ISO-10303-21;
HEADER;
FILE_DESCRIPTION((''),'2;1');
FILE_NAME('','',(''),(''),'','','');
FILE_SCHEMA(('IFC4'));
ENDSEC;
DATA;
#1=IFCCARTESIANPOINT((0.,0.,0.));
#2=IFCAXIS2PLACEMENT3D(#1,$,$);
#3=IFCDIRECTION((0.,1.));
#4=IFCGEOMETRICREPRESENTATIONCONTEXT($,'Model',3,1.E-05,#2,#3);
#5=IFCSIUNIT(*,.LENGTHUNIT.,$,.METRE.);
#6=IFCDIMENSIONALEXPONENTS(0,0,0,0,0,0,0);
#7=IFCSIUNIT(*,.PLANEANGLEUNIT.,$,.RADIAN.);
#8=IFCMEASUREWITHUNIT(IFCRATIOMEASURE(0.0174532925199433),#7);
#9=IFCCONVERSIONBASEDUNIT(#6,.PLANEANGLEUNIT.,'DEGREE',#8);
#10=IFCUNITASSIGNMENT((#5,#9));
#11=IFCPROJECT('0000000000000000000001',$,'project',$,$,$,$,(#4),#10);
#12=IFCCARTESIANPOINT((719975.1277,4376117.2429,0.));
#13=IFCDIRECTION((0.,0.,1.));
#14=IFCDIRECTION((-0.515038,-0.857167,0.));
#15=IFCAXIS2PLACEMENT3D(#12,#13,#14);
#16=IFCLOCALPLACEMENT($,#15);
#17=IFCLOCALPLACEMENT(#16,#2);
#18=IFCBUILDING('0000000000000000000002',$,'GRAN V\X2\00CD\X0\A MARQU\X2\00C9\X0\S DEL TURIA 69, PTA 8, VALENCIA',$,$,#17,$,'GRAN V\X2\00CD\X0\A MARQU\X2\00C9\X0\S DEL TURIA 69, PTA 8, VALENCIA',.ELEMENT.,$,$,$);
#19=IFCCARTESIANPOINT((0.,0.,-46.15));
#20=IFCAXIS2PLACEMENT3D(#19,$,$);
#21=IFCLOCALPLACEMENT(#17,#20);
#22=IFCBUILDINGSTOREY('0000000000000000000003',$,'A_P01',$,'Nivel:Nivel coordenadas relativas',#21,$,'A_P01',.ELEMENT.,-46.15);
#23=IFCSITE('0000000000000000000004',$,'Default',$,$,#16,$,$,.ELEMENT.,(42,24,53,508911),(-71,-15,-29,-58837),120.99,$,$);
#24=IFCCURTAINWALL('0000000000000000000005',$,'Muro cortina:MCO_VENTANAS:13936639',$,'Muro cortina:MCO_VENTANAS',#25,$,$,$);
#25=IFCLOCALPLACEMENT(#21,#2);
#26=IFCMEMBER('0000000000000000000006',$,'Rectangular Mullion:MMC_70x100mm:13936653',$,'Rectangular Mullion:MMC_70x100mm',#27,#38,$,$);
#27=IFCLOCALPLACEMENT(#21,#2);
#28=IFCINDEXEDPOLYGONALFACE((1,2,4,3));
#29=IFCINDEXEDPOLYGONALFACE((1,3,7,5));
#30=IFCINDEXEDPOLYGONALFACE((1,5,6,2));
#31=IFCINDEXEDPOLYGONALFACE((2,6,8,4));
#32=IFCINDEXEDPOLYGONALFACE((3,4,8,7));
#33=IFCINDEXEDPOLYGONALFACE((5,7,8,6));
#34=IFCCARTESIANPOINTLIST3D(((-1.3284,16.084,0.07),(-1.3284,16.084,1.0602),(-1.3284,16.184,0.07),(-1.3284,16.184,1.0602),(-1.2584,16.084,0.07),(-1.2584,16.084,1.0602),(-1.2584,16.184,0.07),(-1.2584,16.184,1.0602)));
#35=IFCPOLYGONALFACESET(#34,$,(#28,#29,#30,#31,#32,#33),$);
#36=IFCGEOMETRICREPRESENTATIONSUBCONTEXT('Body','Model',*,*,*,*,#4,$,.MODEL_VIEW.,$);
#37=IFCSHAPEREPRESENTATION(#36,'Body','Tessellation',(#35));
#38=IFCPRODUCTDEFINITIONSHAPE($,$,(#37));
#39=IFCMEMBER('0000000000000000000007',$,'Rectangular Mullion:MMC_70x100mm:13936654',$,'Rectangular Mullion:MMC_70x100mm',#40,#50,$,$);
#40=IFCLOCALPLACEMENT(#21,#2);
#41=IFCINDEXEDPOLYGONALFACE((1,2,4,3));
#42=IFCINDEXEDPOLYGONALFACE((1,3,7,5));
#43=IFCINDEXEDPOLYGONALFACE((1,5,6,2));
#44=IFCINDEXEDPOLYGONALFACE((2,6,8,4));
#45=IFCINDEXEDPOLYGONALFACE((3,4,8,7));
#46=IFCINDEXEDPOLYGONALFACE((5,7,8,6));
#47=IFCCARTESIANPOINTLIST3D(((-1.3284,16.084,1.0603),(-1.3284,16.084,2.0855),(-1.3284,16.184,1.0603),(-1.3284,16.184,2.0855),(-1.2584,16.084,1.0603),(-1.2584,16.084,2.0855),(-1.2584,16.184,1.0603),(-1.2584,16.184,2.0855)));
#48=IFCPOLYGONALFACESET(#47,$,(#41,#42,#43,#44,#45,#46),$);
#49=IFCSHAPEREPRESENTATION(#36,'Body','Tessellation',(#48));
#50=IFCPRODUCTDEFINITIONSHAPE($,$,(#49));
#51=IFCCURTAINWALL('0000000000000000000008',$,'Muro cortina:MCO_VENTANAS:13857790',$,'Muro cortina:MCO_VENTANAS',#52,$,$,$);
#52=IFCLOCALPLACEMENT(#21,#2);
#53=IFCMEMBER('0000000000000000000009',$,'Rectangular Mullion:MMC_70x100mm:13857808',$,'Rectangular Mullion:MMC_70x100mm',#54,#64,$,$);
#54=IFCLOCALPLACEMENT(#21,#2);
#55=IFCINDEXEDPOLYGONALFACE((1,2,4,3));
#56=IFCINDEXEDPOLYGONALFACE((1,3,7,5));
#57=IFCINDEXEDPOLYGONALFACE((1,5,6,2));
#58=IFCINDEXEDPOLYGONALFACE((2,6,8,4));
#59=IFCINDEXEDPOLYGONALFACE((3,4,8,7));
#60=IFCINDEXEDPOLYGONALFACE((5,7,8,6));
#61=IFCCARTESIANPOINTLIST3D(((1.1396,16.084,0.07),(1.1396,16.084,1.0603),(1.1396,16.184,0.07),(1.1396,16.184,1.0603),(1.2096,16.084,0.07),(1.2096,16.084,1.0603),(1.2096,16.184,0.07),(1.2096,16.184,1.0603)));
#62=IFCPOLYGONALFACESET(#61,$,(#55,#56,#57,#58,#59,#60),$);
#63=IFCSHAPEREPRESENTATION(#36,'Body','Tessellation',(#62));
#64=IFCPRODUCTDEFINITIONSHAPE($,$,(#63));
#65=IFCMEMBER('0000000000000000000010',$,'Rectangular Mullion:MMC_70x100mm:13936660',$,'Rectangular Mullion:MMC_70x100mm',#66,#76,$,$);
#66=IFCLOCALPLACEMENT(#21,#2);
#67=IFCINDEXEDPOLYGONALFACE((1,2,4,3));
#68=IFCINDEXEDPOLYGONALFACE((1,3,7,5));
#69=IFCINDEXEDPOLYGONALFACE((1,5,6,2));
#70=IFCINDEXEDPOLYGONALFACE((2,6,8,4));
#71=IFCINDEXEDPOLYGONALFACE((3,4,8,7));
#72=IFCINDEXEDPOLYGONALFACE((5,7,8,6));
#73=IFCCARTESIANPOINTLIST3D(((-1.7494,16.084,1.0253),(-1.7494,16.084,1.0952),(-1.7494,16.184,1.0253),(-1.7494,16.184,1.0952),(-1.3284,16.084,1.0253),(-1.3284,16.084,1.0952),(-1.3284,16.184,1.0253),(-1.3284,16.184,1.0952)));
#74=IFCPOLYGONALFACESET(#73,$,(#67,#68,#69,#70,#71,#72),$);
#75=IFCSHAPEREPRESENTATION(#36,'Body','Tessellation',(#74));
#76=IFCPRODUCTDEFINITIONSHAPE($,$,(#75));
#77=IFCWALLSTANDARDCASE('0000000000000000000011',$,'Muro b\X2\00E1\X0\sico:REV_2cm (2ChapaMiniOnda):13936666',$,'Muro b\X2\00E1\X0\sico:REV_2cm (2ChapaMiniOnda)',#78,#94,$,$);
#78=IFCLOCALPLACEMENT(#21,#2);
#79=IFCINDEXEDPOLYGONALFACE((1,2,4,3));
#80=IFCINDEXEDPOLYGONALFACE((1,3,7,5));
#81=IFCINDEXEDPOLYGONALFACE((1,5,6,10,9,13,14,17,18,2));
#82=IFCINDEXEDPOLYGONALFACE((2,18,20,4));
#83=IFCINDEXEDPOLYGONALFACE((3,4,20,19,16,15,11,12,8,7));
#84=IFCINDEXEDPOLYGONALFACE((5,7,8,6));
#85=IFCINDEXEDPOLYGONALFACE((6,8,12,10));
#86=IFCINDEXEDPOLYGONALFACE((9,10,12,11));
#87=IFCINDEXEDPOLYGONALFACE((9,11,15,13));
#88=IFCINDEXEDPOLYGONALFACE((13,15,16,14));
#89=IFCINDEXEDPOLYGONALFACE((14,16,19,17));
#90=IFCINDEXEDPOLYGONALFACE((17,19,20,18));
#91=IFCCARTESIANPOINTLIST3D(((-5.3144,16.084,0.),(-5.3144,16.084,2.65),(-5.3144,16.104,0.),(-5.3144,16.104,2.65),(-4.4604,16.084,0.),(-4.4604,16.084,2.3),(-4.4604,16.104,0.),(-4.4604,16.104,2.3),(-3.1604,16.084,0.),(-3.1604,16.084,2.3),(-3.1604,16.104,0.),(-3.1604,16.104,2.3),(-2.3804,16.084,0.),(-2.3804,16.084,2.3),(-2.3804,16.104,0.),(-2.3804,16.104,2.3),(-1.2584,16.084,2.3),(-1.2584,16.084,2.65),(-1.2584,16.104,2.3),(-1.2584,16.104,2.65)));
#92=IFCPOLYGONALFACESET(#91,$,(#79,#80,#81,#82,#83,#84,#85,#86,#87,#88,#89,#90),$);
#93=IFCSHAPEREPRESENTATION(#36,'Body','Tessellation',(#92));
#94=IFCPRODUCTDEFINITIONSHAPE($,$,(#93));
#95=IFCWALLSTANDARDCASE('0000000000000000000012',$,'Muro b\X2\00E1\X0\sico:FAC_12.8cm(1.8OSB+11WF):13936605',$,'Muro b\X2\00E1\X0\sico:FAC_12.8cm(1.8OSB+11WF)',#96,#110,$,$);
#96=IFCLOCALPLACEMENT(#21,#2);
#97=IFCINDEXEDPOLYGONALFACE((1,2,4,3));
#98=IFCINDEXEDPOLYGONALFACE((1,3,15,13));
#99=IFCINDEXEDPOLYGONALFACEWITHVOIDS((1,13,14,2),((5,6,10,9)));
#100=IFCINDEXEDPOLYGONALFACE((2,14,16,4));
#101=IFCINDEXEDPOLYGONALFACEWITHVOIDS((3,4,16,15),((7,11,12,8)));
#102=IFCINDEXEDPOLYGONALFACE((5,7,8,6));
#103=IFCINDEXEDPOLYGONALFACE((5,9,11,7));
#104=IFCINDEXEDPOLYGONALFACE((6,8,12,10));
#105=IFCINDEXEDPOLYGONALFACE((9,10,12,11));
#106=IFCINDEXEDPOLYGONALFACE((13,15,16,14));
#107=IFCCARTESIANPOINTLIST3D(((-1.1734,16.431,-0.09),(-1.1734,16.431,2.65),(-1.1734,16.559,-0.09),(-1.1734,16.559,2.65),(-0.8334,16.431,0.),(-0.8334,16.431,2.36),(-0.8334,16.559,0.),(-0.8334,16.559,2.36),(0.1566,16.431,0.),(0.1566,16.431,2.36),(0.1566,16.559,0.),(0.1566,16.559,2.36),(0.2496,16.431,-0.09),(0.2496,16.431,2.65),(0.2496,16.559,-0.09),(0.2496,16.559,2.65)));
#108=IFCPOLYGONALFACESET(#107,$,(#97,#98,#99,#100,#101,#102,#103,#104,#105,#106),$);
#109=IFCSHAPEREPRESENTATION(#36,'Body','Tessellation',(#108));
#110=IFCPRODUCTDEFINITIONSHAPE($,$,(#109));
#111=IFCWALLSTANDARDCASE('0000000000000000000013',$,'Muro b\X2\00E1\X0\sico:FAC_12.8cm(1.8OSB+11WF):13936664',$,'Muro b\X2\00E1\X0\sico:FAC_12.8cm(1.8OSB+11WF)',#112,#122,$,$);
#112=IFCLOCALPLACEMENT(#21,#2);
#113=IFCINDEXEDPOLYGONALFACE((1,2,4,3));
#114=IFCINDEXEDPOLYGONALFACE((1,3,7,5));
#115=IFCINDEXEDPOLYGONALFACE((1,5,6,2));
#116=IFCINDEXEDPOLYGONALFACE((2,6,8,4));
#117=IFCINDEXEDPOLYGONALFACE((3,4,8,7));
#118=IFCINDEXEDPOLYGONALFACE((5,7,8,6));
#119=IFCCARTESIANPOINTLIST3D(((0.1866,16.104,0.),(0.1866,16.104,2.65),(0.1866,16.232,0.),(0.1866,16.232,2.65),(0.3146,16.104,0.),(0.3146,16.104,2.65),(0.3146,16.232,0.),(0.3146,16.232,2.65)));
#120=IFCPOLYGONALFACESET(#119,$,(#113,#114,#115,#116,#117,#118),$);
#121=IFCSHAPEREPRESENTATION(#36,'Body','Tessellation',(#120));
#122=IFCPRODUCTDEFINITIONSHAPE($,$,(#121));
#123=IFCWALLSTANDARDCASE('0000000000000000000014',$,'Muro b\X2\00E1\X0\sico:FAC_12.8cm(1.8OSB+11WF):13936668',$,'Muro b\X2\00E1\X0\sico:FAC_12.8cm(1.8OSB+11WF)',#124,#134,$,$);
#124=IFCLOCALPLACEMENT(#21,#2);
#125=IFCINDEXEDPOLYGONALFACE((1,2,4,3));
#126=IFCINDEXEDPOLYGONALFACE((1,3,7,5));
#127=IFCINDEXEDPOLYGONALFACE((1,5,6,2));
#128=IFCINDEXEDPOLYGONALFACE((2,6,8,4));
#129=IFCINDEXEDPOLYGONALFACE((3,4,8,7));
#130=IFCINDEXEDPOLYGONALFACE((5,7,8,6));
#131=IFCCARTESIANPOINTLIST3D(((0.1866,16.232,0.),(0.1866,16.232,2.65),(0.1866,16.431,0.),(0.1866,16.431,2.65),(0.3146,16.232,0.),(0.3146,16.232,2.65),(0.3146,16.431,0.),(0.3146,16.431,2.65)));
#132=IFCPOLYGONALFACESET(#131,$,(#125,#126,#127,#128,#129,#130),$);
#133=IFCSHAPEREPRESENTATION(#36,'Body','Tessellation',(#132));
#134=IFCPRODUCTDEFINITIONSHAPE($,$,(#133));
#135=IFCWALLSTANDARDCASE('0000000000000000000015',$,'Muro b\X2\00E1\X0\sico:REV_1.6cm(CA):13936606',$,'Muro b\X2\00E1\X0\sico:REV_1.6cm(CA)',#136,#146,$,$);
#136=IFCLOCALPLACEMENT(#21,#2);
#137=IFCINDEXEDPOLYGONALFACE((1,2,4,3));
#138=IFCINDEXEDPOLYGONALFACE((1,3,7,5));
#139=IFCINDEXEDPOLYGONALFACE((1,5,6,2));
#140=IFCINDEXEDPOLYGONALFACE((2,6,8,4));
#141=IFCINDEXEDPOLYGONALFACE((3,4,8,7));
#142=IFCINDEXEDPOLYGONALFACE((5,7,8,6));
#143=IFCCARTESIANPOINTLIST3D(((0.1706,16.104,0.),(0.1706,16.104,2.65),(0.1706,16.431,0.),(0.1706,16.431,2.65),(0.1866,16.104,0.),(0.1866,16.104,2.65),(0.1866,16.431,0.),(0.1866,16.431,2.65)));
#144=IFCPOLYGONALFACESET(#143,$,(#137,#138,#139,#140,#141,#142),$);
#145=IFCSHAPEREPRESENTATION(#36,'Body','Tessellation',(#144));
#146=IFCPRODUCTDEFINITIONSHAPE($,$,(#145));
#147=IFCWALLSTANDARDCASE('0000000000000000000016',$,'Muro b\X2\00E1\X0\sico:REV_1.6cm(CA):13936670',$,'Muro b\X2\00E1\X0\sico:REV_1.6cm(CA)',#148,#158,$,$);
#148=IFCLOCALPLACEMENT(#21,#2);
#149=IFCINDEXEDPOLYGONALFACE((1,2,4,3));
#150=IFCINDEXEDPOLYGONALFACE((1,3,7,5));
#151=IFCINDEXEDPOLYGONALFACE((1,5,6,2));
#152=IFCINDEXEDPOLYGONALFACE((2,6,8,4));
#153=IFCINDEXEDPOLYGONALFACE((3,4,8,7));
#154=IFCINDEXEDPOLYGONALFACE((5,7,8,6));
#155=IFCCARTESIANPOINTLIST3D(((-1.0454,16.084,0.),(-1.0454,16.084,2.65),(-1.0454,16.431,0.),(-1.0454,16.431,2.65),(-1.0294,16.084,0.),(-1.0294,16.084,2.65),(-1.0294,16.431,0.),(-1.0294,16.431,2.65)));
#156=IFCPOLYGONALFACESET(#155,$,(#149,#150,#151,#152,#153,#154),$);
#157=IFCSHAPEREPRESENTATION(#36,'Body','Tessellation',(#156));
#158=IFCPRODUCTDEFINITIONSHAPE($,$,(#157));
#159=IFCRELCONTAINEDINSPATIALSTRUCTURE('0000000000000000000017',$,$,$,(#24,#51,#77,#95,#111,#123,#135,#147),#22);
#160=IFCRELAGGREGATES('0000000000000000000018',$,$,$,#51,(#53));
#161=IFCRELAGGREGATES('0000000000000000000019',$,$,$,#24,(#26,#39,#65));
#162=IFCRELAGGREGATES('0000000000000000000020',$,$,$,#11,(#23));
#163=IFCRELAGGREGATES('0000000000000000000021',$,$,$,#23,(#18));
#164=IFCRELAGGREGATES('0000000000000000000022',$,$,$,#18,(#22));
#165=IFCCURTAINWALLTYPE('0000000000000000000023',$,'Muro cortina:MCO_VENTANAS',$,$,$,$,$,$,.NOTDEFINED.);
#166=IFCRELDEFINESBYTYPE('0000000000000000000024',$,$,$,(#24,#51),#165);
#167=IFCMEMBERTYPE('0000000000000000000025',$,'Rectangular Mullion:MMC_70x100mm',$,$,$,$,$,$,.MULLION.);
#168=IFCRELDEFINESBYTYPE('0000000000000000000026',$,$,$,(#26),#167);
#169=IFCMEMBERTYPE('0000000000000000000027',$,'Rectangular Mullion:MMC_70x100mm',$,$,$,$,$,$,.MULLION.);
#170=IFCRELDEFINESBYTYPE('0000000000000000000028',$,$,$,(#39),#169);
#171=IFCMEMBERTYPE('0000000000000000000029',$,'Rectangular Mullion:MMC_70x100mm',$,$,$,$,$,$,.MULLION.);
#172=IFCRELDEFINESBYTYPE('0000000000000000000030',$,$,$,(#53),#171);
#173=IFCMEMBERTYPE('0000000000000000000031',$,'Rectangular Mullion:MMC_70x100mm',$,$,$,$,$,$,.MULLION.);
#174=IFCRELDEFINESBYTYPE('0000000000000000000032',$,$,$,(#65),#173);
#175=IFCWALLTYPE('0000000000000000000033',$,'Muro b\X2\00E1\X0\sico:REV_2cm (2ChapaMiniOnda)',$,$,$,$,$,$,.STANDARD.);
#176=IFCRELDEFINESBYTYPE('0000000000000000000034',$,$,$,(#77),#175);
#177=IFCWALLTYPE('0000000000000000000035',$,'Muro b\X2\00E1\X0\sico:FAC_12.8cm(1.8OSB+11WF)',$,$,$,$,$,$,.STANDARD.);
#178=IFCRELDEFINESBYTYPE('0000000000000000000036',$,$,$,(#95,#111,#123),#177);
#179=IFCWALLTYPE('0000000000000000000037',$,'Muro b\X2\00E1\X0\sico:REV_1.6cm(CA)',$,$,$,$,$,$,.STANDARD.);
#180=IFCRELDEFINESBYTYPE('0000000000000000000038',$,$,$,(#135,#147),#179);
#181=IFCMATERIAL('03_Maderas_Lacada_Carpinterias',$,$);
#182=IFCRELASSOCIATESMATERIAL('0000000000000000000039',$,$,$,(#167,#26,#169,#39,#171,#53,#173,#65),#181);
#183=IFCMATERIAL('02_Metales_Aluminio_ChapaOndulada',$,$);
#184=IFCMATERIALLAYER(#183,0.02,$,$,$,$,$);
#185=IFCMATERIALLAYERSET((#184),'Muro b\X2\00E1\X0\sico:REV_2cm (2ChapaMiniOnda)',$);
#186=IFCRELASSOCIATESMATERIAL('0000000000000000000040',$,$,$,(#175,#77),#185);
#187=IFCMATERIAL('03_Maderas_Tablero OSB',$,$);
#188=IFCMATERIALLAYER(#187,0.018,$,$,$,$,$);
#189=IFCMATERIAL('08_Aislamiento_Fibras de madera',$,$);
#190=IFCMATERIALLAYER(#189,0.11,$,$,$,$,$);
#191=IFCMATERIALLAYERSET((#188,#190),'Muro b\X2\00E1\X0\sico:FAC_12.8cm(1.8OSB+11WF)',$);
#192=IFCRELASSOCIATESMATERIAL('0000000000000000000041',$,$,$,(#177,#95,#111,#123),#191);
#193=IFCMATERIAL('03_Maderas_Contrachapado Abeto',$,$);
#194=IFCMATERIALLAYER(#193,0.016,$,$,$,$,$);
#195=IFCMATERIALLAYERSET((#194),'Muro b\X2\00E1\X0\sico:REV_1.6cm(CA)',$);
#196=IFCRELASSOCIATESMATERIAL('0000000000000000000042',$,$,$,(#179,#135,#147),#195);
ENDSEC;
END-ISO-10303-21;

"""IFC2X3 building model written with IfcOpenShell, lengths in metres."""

from ifc_helpers import new_model, entity, si_unit, converted_unit, direction, frame, frame_2d, origin, origin_2d_with_axis, place, context, subcontext, project, spatial, rectangle, extrude, source, transform, mapped, material, layer, layer_set, layer_usage, type_object, type_shapes, element, aggregate, save


model = new_model("IFC2X3")

# Units and contexts
model_context = context("Model", 3, precision=1e-05, world=origin(), true_north=direction((0.0, 1.0)))
body_context = subcontext(model_context, "Body", "Model", "MODEL_VIEW")
ifc_project = project(units=[si_unit("LENGTHUNIT", "METRE"), converted_unit("PLANEANGLEUNIT", "DEGREE", entity("IfcRatioMeasure", 0.0174532925199433), si_unit("PLANEANGLEUNIT", "RADIAN"), dimensions=[0, 0, 0, 0, 0, 0, 0])], contexts=[model_context])

# Site, building, storey
site_placement = place(None, frame((719975.1277, 4376117.2429, 0.0), z_axis=(0.0, 0.0, 1.0), x_axis=(-0.515038, -0.857167, 0.0)))
site = spatial("IfcSite", under=ifc_project, at=site_placement, Name="Default", CompositionType="ELEMENT", RefLatitude=(42, 24, 53, 508911), RefLongitude=(-71, -15, -29, -58837), RefElevation=120.99)
building_placement = place(site_placement, origin())
building = spatial("IfcBuilding", under=site, at=building_placement, Name="GRAN VÍA MARQUÉS DEL TURIA 69, PTA 8, VALENCIA", LongName="GRAN VÍA MARQUÉS DEL TURIA 69, PTA 8, VALENCIA", CompositionType="ELEMENT")
storey_placement = place(building_placement, frame((0.0, 0.0, -46.15)))
storey = spatial("IfcBuildingStorey", under=building, at=storey_placement, Name="A_P01", ObjectType="Nivel:Nivel coordenadas relativas", LongName="A_P01", CompositionType="ELEMENT", Elevation=-46.15)

# Curtain wall, members
curtain_wall_type = type_object("IfcCurtainWallType", Name="Muro cortina:MCO_VENTANAS", PredefinedType="NOTDEFINED")
curtain_wall_1_placement = place(storey_placement, frame((0.0, 0.0, 46.15)))
curtain_wall_1 = element("IfcCurtainWall", 1, at=curtain_wall_1_placement, inside=storey, type_object=curtain_wall_type, Name="Muro cortina:MCO_VENTANAS:13936639", ObjectType="Muro cortina:MCO_VENTANAS")
ifc_material_1 = material(Name="03_Maderas_Lacada_Carpinterias")
member_type_1 = type_object("IfcMemberType", Name="Rectangular Mullion:MMC_70x100mm", PredefinedType="MULLION", material=ifc_material_1)
shared_shape_1 = source(origin(), body_context, "Body", "SweptSolid", [
    extrude(rectangle(XDim=0.1, YDim=0.07, at=origin_2d_with_axis()), frame((-0.035, 0.0, -0.9902), z_axis=(0.0, 0.0, 1.0), x_axis=(0.0, -1.0, 0.0)), (0.0, 0.0, 1.0), 0.9902),
])
type_shapes(member_type_1, [shared_shape_1])
member_1_placement = place(storey_placement, frame((-1.2584, 16.134, 0.07), z_axis=(0.0, 0.0, -1.0), x_axis=(1.0, 0.0, 0.0)))
member_1 = element("IfcMember", 2, at=member_1_placement, type_object=member_type_1, material=ifc_material_1, Name="Rectangular Mullion:MMC_70x100mm:13936653", ObjectType="Rectangular Mullion:MMC_70x100mm", context=body_context, shape_type="MappedRepresentation", body=[
    mapped(shared_shape_1, transform((0.0, 0.0, 0.0), scale=1.0)),
])
member_type_2 = type_object("IfcMemberType", Name="Rectangular Mullion:MMC_70x100mm", PredefinedType="MULLION", material=ifc_material_1)
shared_shape_2 = source(origin(), body_context, "Body", "SweptSolid", [
    extrude(rectangle(XDim=0.1, YDim=0.07, at=origin_2d_with_axis()), frame((-0.035, 0.0, -1.0252), z_axis=(0.0, 0.0, 1.0), x_axis=(0.0, -1.0, 0.0)), (0.0, 0.0, 1.0), 1.0252),
])
type_shapes(member_type_2, [shared_shape_2])
member_2_placement = place(storey_placement, frame((-1.2584, 16.134, 1.0602), z_axis=(0.0, 0.0, -1.0), x_axis=(1.0, 0.0, 0.0)))
member_2 = element("IfcMember", 3, at=member_2_placement, type_object=member_type_2, material=ifc_material_1, Name="Rectangular Mullion:MMC_70x100mm:13936654", ObjectType="Rectangular Mullion:MMC_70x100mm", context=body_context, shape_type="MappedRepresentation", body=[
    mapped(shared_shape_2, transform((0.0, 0.0, 0.0), scale=1.0)),
])

# Curtain wall, member
curtain_wall_2_placement = place(storey_placement, frame((0.0, 0.0, 46.15)))
curtain_wall_2 = element("IfcCurtainWall", 4, at=curtain_wall_2_placement, inside=storey, type_object=curtain_wall_type, Name="Muro cortina:MCO_VENTANAS:13857790", ObjectType="Muro cortina:MCO_VENTANAS")
member_type_3 = type_object("IfcMemberType", Name="Rectangular Mullion:MMC_70x100mm", PredefinedType="MULLION", material=ifc_material_1)
shared_shape_3 = source(origin(), body_context, "Body", "SweptSolid", [
    extrude(rectangle(XDim=0.1, YDim=0.07, at=origin_2d_with_axis()), frame((-0.035, 0.0, -0.9902), z_axis=(0.0, 0.0, 1.0), x_axis=(0.0, -1.0, 0.0)), (0.0, 0.0, 1.0), 0.9902),
])
type_shapes(member_type_3, [shared_shape_3])
member_3_placement = place(storey_placement, frame((1.1396, 16.134, 1.0602), z_axis=(0.0, 0.0, 1.0), x_axis=(-1.0, 0.0, 0.0)))
member_3 = element("IfcMember", 5, at=member_3_placement, type_object=member_type_3, material=ifc_material_1, Name="Rectangular Mullion:MMC_70x100mm:13857808", ObjectType="Rectangular Mullion:MMC_70x100mm", context=body_context, shape_type="MappedRepresentation", body=[
    mapped(shared_shape_3, transform((0.0, 0.0, 0.0), scale=1.0)),
])
aggregate(curtain_wall_2, [member_3])

# Member
member_type_4 = type_object("IfcMemberType", Name="Rectangular Mullion:MMC_70x100mm", PredefinedType="MULLION", material=ifc_material_1)
shared_shape_4 = source(origin(), body_context, "Body", "SweptSolid", [
    extrude(rectangle(XDim=0.1, YDim=0.07, at=origin_2d_with_axis()), frame((0.0, 0.0, -0.421), z_axis=(0.0, 0.0, 1.0), x_axis=(0.0, -1.0, 0.0)), (0.0, 0.0, 1.0), 0.421),
])
type_shapes(member_type_4, [shared_shape_4])
member_4_placement = place(storey_placement, frame((-1.3284, 16.134, 1.0602), z_axis=(1.0, 0.0, 0.0), x_axis=(0.0, 0.0, 1.0)))
member_4 = element("IfcMember", 6, at=member_4_placement, type_object=member_type_4, material=ifc_material_1, Name="Rectangular Mullion:MMC_70x100mm:13936660", ObjectType="Rectangular Mullion:MMC_70x100mm", context=body_context, shape_type="MappedRepresentation", body=[
    mapped(shared_shape_4, transform((0.0, 0.0, 0.0), scale=1.0)),
])
aggregate(curtain_wall_1, [member_1, member_2, member_4])

# Wall, openings
ifc_material_2 = material(Name="02_Metales_Aluminio_ChapaOndulada")
ifc_layer_1 = layer(ifc_material_2, 0.02)
ifc_layer_set_1 = layer_set([ifc_layer_1], Name="Muro básico:REV_2cm (2ChapaMiniOnda)")
ifc_layer_usage_1 = layer_usage(ifc_layer_set_1, "AXIS2", "NEGATIVE", 0.01)
wall_type_1 = type_object("IfcWallType", Name="Muro básico:REV_2cm (2ChapaMiniOnda)", PredefinedType="STANDARD", material=ifc_layer_set_1)
wall_1_placement = place(storey_placement, frame((-1.2584, 16.094, 0.0), z_axis=(0.0, 0.0, 1.0), x_axis=(-1.0, 0.0, 0.0)))
wall_1 = element("IfcWallStandardCase", 7, at=wall_1_placement, inside=storey, type_object=wall_type_1, material=ifc_layer_usage_1, Name="Muro básico:REV_2cm (2ChapaMiniOnda):13936666", ObjectType="Muro básico:REV_2cm (2ChapaMiniOnda)", context=body_context, shape_type="SweptSolid", body=[
    extrude(rectangle(XDim=4.056, YDim=0.02, at=frame_2d((2.028, 0.0), x_axis=(-1.0, 0.0))), origin(), (0.0, 0.0, 1.0), 2.65),
])
opening_1_placement = place(wall_1_placement, origin())
element("IfcOpeningElement", 8, at=opening_1_placement, cuts=wall_1, ObjectType="Opening", context=body_context, shape_type="SweptSolid", body=[
    extrude(rectangle(XDim=2.3, YDim=1.122, at=frame_2d((0.0, 0.0), x_axis=(1.0, 0.0))), frame((0.561, -0.01, 1.15), z_axis=(0.0, 1.0, 0.0), x_axis=(0.0, 0.0, -1.0)), (0.0, 0.0, 1.0), 0.02),
])
opening_2_placement = place(wall_1_placement, origin())
element("IfcOpeningElement", 9, at=opening_2_placement, cuts=wall_1, ObjectType="Opening", context=body_context, shape_type="SweptSolid", body=[
    extrude(rectangle(XDim=2.3, YDim=1.3, at=frame_2d((0.0, 0.0), x_axis=(0.0, 1.0))), frame((2.552, -0.1624, 1.15), z_axis=(0.0, 1.0, 0.0), x_axis=(-1.0, 0.0, 0.0)), (0.0, 0.0, 1.0), 0.3248),
])

# Wall, opening
ifc_material_3 = material(Name="03_Maderas_Tablero OSB")
ifc_layer_2 = layer(ifc_material_3, 0.018)
ifc_material_4 = material(Name="08_Aislamiento_Fibras de madera")
ifc_layer_3 = layer(ifc_material_4, 0.11)
ifc_layer_set_2 = layer_set([ifc_layer_2, ifc_layer_3], Name="Muro básico:FAC_12.8cm(1.8OSB+11WF)")
ifc_layer_usage_2 = layer_usage(ifc_layer_set_2, "AXIS2", "NEGATIVE", 0.064)
wall_type_2 = type_object("IfcWallType", Name="Muro básico:FAC_12.8cm(1.8OSB+11WF)", PredefinedType="STANDARD", material=ifc_layer_set_2)
wall_2_placement = place(storey_placement, frame((0.2496, 16.495, -0.09), z_axis=(0.0, 0.0, 1.0), x_axis=(-1.0, 0.0, 0.0)))
wall_2 = element("IfcWallStandardCase", 10, at=wall_2_placement, inside=storey, type_object=wall_type_2, material=ifc_layer_usage_2, Name="Muro básico:FAC_12.8cm(1.8OSB+11WF):13936605", ObjectType="Muro básico:FAC_12.8cm(1.8OSB+11WF)", context=body_context, shape_type="SweptSolid", body=[
    extrude(rectangle(XDim=1.423, YDim=0.128, at=frame_2d((0.7115, 0.0), x_axis=(-1.0, 0.0))), origin(), (0.0, 0.0, 1.0), 2.74),
])
opening_3_placement = place(wall_2_placement, frame((1.083, 0.064, 0.09)))
element("IfcOpeningElement", 11, at=opening_3_placement, cuts=wall_2, ObjectType="Opening", context=body_context, shape_type="SweptSolid", body=[
    extrude(rectangle(XDim=2.36, YDim=0.99, at=frame_2d((1.18, 0.495), x_axis=(-1.0, 0.0))), frame((0.0, 0.0, 0.0), z_axis=(0.0, -1.0, 0.0), x_axis=(0.0, 0.0, 1.0)), (0.0, 0.0, 1.0), 0.128),
])

# Wall
ifc_layer_usage_3 = layer_usage(ifc_layer_set_2, "AXIS2", "NEGATIVE", 0.064)
wall_3_placement = place(storey_placement, frame((0.3146, 16.168, 0.0), z_axis=(0.0, 0.0, 1.0), x_axis=(-1.0, 0.0, 0.0)))
element("IfcWallStandardCase", 12, at=wall_3_placement, inside=storey, type_object=wall_type_2, material=ifc_layer_usage_3, Name="Muro básico:FAC_12.8cm(1.8OSB+11WF):13936664", ObjectType="Muro básico:FAC_12.8cm(1.8OSB+11WF)", context=body_context, shape_type="SweptSolid", body=[
    extrude(rectangle(XDim=0.128, YDim=0.128, at=frame_2d((0.064, 0.0), x_axis=(-1.0, 0.0))), origin(), (0.0, 0.0, 1.0), 2.65),
])

# Walls
ifc_layer_usage_4 = layer_usage(ifc_layer_set_2, "AXIS2", "NEGATIVE", 0.064)
wall_4_placement = place(storey_placement, frame((0.2506, 16.232, 0.0), z_axis=(0.0, 0.0, 1.0), x_axis=(0.0, 1.0, 0.0)))
element("IfcWallStandardCase", 13, at=wall_4_placement, inside=storey, type_object=wall_type_2, material=ifc_layer_usage_4, Name="Muro básico:FAC_12.8cm(1.8OSB+11WF):13936668", ObjectType="Muro básico:FAC_12.8cm(1.8OSB+11WF)", context=body_context, shape_type="SweptSolid", body=[
    extrude(rectangle(XDim=0.199, YDim=0.128, at=frame_2d((0.0995, 0.0), x_axis=(-1.0, 0.0))), origin(), (0.0, 0.0, 1.0), 2.65),
])
ifc_material_5 = material(Name="03_Maderas_Contrachapado Abeto")
ifc_layer_4 = layer(ifc_material_5, 0.016)
ifc_layer_set_3 = layer_set([ifc_layer_4], Name="Muro básico:REV_1.6cm(CA)")
ifc_layer_usage_5 = layer_usage(ifc_layer_set_3, "AXIS2", "NEGATIVE", 0.008)
wall_type_3 = type_object("IfcWallType", Name="Muro básico:REV_1.6cm(CA)", PredefinedType="STANDARD", material=ifc_layer_set_3)
wall_5_placement = place(storey_placement, frame((0.1786, 16.104, 0.0), z_axis=(0.0, 0.0, 1.0), x_axis=(0.0, 1.0, 0.0)))
element("IfcWallStandardCase", 14, at=wall_5_placement, inside=storey, type_object=wall_type_3, material=ifc_layer_usage_5, Name="Muro básico:REV_1.6cm(CA):13936606", ObjectType="Muro básico:REV_1.6cm(CA)", context=body_context, shape_type="SweptSolid", body=[
    extrude(rectangle(XDim=0.327, YDim=0.016, at=frame_2d((0.1635, 0.0), x_axis=(-1.0, 0.0))), origin(), (0.0, 0.0, 1.0), 2.65),
])
ifc_layer_usage_6 = layer_usage(ifc_layer_set_3, "AXIS2", "NEGATIVE", 0.008)
wall_6_placement = place(storey_placement, frame((-1.0374, 16.084, 0.0), z_axis=(0.0, 0.0, 1.0), x_axis=(0.0, 1.0, 0.0)))
element("IfcWallStandardCase", 15, at=wall_6_placement, inside=storey, type_object=wall_type_3, material=ifc_layer_usage_6, Name="Muro básico:REV_1.6cm(CA):13936670", ObjectType="Muro básico:REV_1.6cm(CA)", context=body_context, shape_type="SweptSolid", body=[
    extrude(rectangle(XDim=0.347, YDim=0.016, at=frame_2d((0.1735, 0.0), x_axis=(-1.0, 0.0))), origin(), (0.0, 0.0, 1.0), 2.65),
])

save(model, "model.ifc")
